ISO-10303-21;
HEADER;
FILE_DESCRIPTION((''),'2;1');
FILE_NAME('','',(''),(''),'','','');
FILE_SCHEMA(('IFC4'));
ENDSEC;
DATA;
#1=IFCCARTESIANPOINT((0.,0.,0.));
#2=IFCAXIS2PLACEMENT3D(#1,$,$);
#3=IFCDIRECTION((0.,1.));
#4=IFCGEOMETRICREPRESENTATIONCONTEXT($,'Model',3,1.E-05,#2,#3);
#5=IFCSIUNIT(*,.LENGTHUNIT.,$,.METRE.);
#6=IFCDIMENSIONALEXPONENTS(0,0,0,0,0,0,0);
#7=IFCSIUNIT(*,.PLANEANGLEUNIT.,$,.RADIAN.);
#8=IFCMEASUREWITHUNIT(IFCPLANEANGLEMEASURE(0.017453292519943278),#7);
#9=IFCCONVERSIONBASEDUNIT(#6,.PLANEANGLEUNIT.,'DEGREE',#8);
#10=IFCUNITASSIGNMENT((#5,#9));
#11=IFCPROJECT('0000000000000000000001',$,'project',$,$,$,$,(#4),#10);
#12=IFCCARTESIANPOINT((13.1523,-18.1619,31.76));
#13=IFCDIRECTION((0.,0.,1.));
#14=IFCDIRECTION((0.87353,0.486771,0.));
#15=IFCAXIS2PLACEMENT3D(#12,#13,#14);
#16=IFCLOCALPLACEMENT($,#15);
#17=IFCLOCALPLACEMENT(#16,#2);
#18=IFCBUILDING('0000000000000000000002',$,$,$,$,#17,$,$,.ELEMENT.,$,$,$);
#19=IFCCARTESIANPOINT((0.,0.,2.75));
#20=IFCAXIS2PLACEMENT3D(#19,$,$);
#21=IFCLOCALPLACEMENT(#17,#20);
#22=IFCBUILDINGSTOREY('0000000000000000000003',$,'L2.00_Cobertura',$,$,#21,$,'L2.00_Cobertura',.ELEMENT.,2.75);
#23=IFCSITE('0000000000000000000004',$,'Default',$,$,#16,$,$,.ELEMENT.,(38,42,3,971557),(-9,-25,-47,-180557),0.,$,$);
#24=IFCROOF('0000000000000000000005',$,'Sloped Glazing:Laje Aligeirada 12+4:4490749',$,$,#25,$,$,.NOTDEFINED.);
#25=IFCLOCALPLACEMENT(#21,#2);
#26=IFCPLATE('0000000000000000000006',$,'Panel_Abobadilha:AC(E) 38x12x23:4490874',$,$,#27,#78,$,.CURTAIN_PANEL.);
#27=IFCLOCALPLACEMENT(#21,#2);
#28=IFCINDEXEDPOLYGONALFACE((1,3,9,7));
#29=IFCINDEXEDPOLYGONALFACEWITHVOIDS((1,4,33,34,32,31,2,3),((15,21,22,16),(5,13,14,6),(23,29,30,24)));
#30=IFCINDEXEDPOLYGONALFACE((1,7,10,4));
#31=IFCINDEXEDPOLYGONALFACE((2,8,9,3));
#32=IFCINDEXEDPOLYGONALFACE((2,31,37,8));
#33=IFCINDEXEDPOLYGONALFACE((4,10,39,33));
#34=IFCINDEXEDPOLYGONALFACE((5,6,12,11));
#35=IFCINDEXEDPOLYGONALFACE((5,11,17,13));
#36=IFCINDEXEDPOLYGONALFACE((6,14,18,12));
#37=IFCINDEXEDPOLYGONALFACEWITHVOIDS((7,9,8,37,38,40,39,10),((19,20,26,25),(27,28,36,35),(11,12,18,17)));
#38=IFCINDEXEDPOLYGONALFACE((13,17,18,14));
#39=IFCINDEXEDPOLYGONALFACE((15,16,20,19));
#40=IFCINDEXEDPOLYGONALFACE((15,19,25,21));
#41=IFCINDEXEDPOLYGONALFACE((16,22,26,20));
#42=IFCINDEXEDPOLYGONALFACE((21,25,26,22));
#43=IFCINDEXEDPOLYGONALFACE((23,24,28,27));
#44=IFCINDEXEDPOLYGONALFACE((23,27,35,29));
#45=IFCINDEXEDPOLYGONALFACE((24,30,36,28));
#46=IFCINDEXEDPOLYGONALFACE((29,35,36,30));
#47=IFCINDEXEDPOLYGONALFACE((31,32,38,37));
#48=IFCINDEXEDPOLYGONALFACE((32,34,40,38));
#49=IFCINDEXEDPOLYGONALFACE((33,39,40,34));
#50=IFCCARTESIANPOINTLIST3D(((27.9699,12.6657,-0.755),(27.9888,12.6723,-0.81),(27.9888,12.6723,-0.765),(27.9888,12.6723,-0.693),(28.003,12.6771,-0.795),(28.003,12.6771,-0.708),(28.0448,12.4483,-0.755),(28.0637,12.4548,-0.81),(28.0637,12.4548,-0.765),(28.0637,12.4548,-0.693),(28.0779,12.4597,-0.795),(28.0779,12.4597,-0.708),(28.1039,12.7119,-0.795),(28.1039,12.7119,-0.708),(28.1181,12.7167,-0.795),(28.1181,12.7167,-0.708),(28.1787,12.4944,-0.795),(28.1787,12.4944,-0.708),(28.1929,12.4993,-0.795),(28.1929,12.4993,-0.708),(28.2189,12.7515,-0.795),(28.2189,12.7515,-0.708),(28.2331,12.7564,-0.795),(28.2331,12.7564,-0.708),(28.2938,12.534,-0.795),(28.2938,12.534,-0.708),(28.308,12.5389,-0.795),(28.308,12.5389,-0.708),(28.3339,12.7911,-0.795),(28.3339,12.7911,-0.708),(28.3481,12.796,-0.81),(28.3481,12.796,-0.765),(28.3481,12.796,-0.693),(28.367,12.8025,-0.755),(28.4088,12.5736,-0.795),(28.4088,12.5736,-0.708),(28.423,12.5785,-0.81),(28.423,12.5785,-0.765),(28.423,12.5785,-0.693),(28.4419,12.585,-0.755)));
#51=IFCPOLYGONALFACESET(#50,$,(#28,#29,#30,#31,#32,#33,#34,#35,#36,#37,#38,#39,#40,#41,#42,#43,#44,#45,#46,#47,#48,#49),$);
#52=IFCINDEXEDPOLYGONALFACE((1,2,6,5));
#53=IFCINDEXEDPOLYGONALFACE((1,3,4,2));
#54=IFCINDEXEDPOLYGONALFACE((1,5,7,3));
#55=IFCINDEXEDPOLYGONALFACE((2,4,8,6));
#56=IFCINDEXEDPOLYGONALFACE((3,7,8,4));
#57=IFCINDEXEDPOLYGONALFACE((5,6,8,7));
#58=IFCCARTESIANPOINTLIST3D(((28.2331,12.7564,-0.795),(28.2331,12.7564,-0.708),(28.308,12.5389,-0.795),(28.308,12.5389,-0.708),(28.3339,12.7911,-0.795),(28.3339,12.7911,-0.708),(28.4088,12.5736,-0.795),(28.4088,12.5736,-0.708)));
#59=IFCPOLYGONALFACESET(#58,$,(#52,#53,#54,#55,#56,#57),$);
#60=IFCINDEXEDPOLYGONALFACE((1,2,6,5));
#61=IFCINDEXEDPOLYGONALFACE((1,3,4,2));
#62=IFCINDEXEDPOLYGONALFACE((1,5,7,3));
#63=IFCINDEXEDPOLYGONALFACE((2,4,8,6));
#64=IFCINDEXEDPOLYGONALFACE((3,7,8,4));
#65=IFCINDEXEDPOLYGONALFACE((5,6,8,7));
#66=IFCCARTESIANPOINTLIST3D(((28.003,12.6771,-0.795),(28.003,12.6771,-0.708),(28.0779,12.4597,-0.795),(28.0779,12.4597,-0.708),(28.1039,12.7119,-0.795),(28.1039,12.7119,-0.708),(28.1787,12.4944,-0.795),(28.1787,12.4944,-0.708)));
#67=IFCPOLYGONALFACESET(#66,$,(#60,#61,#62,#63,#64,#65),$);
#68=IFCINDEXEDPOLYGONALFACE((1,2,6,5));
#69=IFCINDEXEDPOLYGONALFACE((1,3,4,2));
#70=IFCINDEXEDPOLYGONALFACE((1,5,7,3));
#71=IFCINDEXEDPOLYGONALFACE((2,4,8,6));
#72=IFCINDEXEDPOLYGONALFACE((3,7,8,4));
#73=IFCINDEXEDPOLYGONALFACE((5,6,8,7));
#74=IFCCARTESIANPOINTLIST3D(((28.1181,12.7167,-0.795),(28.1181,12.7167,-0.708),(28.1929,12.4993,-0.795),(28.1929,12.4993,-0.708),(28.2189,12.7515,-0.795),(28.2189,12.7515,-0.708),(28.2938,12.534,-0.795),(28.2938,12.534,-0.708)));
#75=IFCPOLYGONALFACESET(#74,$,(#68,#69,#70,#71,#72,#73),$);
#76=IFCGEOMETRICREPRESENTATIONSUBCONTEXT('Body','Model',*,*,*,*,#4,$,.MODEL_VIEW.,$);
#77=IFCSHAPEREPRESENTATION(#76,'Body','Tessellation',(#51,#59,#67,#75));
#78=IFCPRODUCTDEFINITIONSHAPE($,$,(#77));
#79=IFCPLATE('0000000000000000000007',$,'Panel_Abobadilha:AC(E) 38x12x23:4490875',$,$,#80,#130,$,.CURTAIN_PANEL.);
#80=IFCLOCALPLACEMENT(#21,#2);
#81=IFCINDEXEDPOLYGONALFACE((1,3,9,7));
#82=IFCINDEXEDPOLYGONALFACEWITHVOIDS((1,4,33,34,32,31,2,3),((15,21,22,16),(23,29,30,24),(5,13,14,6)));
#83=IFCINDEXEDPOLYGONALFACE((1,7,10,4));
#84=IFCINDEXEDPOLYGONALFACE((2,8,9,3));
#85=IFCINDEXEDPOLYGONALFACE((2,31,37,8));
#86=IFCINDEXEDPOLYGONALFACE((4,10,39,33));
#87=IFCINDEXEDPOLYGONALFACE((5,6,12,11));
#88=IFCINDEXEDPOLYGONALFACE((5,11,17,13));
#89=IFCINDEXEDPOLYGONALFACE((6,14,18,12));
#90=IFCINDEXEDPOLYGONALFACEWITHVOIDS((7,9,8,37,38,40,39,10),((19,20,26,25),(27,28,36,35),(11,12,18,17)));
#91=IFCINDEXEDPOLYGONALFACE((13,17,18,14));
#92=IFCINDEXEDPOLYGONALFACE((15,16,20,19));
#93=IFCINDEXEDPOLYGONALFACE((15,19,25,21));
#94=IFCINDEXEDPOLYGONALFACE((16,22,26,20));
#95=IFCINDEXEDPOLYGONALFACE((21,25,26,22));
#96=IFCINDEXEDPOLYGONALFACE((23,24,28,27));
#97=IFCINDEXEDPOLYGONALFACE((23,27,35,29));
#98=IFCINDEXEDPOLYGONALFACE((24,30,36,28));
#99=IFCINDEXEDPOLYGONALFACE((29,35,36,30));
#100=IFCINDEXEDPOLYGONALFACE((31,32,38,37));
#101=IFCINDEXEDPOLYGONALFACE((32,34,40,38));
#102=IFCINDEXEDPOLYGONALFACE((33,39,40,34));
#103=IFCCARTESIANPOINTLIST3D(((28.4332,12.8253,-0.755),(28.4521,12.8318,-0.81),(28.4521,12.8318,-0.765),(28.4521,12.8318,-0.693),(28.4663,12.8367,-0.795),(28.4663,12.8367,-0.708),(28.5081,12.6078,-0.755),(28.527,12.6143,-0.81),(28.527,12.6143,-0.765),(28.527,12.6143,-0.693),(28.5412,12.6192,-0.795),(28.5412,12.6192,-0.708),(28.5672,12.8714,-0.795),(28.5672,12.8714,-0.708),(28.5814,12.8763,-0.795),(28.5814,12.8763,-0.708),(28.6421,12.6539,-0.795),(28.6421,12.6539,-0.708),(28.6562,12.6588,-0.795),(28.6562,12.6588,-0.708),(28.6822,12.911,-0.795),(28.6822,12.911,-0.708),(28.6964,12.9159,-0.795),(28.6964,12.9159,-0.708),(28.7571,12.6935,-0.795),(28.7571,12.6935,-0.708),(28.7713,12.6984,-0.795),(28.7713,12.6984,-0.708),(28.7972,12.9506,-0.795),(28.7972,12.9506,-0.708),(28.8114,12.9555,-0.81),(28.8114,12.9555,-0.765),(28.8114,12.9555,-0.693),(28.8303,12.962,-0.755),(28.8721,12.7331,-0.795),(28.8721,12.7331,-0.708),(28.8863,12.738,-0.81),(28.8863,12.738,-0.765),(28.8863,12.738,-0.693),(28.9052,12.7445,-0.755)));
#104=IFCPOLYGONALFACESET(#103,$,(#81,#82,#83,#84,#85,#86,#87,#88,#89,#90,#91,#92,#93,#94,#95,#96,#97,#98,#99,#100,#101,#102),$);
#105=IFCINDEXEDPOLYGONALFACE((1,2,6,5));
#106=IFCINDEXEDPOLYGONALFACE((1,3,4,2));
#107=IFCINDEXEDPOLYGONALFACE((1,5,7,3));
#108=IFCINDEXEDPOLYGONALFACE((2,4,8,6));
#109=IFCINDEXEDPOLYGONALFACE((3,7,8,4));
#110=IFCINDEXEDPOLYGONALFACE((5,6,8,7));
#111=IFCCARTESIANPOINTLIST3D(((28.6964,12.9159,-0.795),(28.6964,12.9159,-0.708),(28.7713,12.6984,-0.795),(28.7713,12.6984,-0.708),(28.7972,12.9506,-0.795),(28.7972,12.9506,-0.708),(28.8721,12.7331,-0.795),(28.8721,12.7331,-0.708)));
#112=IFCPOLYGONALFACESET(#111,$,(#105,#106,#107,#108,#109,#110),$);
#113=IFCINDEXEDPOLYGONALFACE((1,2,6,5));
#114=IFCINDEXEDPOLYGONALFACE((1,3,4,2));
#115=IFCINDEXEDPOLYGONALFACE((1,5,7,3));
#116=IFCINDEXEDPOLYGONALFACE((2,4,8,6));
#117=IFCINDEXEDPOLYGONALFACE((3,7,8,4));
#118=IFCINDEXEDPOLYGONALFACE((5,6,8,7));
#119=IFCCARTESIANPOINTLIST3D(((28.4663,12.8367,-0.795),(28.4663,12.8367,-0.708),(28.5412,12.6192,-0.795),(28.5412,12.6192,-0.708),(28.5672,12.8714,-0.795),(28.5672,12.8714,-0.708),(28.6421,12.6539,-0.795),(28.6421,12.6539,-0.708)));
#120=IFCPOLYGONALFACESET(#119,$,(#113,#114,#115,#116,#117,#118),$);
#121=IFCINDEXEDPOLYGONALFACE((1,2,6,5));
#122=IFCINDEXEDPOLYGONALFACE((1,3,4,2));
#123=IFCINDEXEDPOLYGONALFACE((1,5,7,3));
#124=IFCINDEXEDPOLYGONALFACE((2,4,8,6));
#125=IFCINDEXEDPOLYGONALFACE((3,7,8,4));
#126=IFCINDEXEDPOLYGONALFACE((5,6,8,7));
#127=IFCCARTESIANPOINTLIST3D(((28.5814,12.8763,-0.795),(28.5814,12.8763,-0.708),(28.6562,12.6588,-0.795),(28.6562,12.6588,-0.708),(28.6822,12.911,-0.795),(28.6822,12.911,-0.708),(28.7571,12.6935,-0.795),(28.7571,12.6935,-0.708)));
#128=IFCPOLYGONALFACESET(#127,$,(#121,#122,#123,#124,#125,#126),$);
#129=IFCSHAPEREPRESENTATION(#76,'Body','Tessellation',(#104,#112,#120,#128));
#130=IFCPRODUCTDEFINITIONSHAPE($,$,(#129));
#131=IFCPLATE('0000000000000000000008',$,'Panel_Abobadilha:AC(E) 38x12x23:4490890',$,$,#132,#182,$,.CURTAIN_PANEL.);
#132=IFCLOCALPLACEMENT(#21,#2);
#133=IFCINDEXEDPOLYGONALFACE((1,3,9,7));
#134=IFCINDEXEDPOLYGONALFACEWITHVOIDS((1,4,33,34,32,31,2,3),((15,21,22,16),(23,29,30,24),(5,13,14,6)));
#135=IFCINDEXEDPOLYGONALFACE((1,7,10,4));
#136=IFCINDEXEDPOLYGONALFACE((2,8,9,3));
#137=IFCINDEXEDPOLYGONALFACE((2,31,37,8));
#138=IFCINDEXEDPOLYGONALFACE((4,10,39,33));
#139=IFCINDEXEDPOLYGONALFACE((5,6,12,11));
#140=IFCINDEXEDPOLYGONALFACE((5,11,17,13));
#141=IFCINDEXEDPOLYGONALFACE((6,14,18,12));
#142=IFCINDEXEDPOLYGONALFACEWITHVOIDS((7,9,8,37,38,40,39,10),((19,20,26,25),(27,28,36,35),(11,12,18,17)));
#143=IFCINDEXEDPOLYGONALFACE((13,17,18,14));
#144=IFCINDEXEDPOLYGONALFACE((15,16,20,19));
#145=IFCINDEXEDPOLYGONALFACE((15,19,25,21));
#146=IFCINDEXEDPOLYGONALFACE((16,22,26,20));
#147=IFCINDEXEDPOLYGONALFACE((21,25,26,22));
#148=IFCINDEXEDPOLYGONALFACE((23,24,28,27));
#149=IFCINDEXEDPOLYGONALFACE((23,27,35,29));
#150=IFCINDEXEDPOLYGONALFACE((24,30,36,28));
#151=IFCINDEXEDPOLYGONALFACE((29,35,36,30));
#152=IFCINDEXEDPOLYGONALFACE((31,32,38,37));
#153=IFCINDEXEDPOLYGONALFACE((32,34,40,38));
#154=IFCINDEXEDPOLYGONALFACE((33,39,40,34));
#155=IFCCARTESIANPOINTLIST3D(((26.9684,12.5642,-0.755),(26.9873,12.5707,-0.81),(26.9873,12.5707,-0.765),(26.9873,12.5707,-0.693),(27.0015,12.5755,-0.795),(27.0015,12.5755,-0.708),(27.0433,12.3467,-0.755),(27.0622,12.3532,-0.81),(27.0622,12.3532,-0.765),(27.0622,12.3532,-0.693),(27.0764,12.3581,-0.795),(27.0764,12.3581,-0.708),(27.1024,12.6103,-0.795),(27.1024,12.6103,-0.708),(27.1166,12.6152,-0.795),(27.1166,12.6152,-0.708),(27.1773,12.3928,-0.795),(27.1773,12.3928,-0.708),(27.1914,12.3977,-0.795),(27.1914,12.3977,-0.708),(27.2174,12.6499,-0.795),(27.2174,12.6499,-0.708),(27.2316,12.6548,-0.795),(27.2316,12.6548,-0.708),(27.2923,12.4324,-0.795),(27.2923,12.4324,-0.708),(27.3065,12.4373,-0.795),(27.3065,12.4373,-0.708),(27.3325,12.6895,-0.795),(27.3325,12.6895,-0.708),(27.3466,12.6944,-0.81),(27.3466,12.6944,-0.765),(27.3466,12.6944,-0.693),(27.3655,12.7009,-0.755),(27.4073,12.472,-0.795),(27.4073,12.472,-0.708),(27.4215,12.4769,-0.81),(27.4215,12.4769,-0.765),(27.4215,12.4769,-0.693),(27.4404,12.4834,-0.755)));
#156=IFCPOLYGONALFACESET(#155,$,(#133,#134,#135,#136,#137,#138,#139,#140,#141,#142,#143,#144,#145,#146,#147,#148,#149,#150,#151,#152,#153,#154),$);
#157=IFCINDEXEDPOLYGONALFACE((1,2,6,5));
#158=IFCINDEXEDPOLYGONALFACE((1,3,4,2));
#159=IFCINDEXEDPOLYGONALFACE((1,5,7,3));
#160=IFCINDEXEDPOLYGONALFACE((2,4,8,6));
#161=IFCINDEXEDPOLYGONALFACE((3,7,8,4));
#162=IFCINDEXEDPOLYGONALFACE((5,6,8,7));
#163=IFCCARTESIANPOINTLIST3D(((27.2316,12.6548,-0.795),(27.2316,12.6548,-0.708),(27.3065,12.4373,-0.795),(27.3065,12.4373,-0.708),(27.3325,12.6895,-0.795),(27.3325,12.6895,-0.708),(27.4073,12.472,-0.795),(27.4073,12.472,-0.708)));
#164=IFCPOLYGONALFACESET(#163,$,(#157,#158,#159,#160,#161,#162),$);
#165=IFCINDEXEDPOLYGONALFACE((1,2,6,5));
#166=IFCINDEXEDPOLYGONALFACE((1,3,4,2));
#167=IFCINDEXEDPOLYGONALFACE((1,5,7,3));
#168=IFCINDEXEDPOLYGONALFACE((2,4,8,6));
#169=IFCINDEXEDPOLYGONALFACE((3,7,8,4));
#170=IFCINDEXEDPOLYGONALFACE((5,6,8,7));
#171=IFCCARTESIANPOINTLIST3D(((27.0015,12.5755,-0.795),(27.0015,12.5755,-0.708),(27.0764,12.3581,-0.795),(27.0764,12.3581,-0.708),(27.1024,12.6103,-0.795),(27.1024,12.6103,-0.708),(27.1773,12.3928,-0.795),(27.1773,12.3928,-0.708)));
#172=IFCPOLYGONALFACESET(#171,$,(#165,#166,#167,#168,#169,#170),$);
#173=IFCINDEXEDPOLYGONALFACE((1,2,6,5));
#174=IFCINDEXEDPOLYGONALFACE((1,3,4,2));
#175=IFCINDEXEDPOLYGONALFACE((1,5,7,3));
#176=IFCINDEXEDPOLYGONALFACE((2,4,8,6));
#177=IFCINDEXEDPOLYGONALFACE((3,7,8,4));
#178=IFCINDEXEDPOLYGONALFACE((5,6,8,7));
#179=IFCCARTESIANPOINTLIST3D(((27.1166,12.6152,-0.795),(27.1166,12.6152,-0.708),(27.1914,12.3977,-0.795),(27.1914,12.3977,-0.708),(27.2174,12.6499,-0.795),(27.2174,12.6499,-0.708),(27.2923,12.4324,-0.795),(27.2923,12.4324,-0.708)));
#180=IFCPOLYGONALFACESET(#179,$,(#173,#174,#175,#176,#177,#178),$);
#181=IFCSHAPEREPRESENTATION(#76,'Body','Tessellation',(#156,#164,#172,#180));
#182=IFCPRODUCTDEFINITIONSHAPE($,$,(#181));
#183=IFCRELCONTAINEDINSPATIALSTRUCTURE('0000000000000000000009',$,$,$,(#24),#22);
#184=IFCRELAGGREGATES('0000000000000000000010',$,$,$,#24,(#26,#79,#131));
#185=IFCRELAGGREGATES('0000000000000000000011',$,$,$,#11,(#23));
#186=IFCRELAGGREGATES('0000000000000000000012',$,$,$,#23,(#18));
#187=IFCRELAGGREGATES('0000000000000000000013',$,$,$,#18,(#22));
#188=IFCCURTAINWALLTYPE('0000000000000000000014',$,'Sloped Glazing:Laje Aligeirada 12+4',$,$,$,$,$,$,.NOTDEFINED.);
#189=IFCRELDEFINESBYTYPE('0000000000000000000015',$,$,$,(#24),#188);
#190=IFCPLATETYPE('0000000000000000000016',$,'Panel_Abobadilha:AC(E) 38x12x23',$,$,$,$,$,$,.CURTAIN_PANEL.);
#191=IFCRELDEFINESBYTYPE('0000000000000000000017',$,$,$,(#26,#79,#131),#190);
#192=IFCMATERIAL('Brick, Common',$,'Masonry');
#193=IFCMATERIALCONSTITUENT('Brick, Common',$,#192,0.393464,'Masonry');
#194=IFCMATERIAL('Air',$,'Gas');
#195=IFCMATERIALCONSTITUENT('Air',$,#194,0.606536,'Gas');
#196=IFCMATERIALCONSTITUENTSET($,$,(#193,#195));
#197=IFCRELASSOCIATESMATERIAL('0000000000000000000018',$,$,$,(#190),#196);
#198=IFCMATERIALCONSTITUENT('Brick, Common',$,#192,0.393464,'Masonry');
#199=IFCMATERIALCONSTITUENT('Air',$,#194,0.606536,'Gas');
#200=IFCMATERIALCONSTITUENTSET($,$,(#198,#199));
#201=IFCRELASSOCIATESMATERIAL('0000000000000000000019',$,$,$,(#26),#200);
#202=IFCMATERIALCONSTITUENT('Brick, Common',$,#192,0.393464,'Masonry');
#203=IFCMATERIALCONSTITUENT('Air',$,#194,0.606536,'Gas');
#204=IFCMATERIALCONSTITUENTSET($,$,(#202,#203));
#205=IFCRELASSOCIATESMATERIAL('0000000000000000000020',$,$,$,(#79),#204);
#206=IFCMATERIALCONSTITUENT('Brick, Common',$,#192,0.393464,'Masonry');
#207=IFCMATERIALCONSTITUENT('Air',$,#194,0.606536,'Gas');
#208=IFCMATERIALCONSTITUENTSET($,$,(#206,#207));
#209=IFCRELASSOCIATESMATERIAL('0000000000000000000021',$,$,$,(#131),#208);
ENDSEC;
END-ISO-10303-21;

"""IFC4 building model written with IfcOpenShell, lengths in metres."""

from ifc_helpers import new_model, entity, si_unit, converted_unit, direction, frame, origin, place, context, subcontext, project, spatial, indexed_curve, outline, extrude, source, transform, mapped, material, constituent, constituent_set, type_object, type_shapes, element, aggregate, save


model = new_model("IFC4")

# Units and contexts
model_context = context("Model", 3, precision=1e-05, world=origin(), true_north=direction((0.0, 1.0)))
body_context = subcontext(model_context, "Body", "Model", "MODEL_VIEW")
ifc_project = project(units=[si_unit("LENGTHUNIT", "METRE"), converted_unit("PLANEANGLEUNIT", "DEGREE", entity("IfcPlaneAngleMeasure", 0.017453292519943278), si_unit("PLANEANGLEUNIT", "RADIAN"), dimensions=[0, 0, 0, 0, 0, 0, 0])], contexts=[model_context])

# Site, building, storey
site_placement = place(None, frame((13.1523, -18.1619, 31.76), z_axis=(0.0, 0.0, 1.0), x_axis=(0.87353, 0.486771, 0.0)))
site = spatial("IfcSite", under=ifc_project, at=site_placement, Name="Default", CompositionType="ELEMENT", RefLatitude=(38, 42, 3, 971557), RefLongitude=(-9, -25, -47, -180557), RefElevation=0.0)
building_placement = place(site_placement, origin())
building = spatial("IfcBuilding", under=site, at=building_placement, CompositionType="ELEMENT")
storey_placement = place(building_placement, frame((0.0, 0.0, 2.75)))
storey = spatial("IfcBuildingStorey", under=building, at=storey_placement, Name="L2.00_Cobertura", LongName="L2.00_Cobertura", CompositionType="ELEMENT", Elevation=2.75)

# Roof, plates
curtain_wall_type = type_object("IfcCurtainWallType", Name="Sloped Glazing:Laje Aligeirada 12+4", PredefinedType="NOTDEFINED")
roof_placement = place(storey_placement, frame((0.0, 0.0, -2.75)))
roof = element("IfcRoof", 1, at=roof_placement, inside=storey, type_object=curtain_wall_type, Name="Sloped Glazing:Laje Aligeirada 12+4:4490749", PredefinedType="NOTDEFINED")
ifc_material_1 = material(Name="Brick, Common", Category="Masonry")
ifc_material_2 = material(Name="Air", Category="Gas")
ifc_constituent_1 = constituent(ifc_material_1, Name="Brick, Common", Category="Masonry", fraction=0.393464)
ifc_constituent_2 = constituent(ifc_material_2, Name="Air", Category="Gas", fraction=0.606536)
ifc_constituent_set_1 = constituent_set(constituents=[ifc_constituent_1, ifc_constituent_2])
plate_type_1 = type_object("IfcPlateType", Name="Panel_Abobadilha:AC(E) 38x12x23", PredefinedType="CURTAIN_PANEL", material=ifc_constituent_set_1)
shared_shape_1 = source(origin(), body_context, "Body", "SweptSolid", [
    extrude(outline(indexed_curve([(-0.19, -0.0543), (0.19, -0.0543), (0.19, -0.0093), (0.21, 0.0007), (0.19, 0.0628), (-0.19, 0.0628), (-0.21, 0.0007), (-0.19, -0.0093), (-0.19, -0.0543)], self_intersect=False), holes=[indexed_curve([(-0.0683, 0.0477), (-0.0683, -0.0393), (-0.175, -0.0393), (-0.175, 0.0477), (-0.0683, 0.0477)], self_intersect=False), indexed_curve([(0.0533, 0.0477), (0.0533, -0.0393), (-0.0533, -0.0393), (-0.0533, 0.0477), (0.0533, 0.0477)], self_intersect=False), indexed_curve([(0.175, 0.0477), (0.175, -0.0393), (0.0683, -0.0393), (0.0683, 0.0477), (0.175, 0.0477)], self_intersect=False)]), frame((0.0, 0.0543, 0.0)), (0.0, 0.0, 1.0), 0.23),
    extrude(outline(indexed_curve([(-0.0533, -0.0435), (0.0533, -0.0435), (0.0533, 0.0435), (-0.0533, 0.0435), (-0.0533, -0.0435)], self_intersect=False)), frame((0.1217, 0.0585, 0.0), z_axis=(0.0, 0.0, 1.0), x_axis=(-1.0, 0.0, 0.0)), (0.0, 0.0, 1.0), 0.23),
    extrude(outline(indexed_curve([(-0.0533, -0.0435), (0.0533, -0.0435), (0.0533, 0.0435), (-0.0533, 0.0435), (-0.0533, -0.0435)], self_intersect=False)), frame((-0.1217, 0.0585, 0.0), z_axis=(0.0, 0.0, 1.0), x_axis=(-1.0, 0.0, 0.0)), (0.0, 0.0, 1.0), 0.23),
    extrude(outline(indexed_curve([(-0.0533, -0.0435), (0.0533, -0.0435), (0.0533, 0.0435), (-0.0533, 0.0435), (-0.0533, -0.0435)], self_intersect=False)), frame((0.0, 0.0585, 0.0), z_axis=(0.0, 0.0, 1.0), x_axis=(-1.0, 0.0, 0.0)), (0.0, 0.0, 1.0), 0.23),
])
type_shapes(plate_type_1, [shared_shape_1])
ifc_constituent_3 = constituent(ifc_material_1, Name="Brick, Common", Category="Masonry", fraction=0.393464)
ifc_constituent_4 = constituent(ifc_material_2, Name="Air", Category="Gas", fraction=0.606536)
ifc_constituent_set_2 = constituent_set(constituents=[ifc_constituent_3, ifc_constituent_4])
plate_1_placement = place(roof_placement, frame((28.1685, 12.7341, 1.94), z_axis=(0.325568, -0.945519, 0.0), x_axis=(0.945519, 0.325568, 0.0)))
plate_1 = element("IfcPlate", 2, at=plate_1_placement, type_object=plate_type_1, material=ifc_constituent_set_2, Name="Panel_Abobadilha:AC(E) 38x12x23:4490874", PredefinedType="CURTAIN_PANEL", context=body_context, shape_type="MappedRepresentation", body=[
    mapped(shared_shape_1, transform((0.0, 0.0, 0.0), scale=1.0)),
])
ifc_constituent_5 = constituent(ifc_material_1, Name="Brick, Common", Category="Masonry", fraction=0.393464)
ifc_constituent_6 = constituent(ifc_material_2, Name="Air", Category="Gas", fraction=0.606536)
ifc_constituent_set_3 = constituent_set(constituents=[ifc_constituent_5, ifc_constituent_6])
plate_2_placement = place(roof_placement, frame((28.6318, 12.8936, 1.94), z_axis=(0.325568, -0.945519, 0.0), x_axis=(0.945519, 0.325568, 0.0)))
plate_2 = element("IfcPlate", 3, at=plate_2_placement, type_object=plate_type_1, material=ifc_constituent_set_3, Name="Panel_Abobadilha:AC(E) 38x12x23:4490875", PredefinedType="CURTAIN_PANEL", context=body_context, shape_type="MappedRepresentation", body=[
    mapped(shared_shape_1, transform((0.0, 0.0, 0.0), scale=1.0)),
])
ifc_constituent_7 = constituent(ifc_material_1, Name="Brick, Common", Category="Masonry", fraction=0.393464)
ifc_constituent_8 = constituent(ifc_material_2, Name="Air", Category="Gas", fraction=0.606536)
ifc_constituent_set_4 = constituent_set(constituents=[ifc_constituent_7, ifc_constituent_8])
plate_3_placement = place(roof_placement, frame((27.167, 12.6325, 1.94), z_axis=(0.325568, -0.945519, 0.0), x_axis=(0.945519, 0.325568, 0.0)))
plate_3 = element("IfcPlate", 4, at=plate_3_placement, type_object=plate_type_1, material=ifc_constituent_set_4, Name="Panel_Abobadilha:AC(E) 38x12x23:4490890", PredefinedType="CURTAIN_PANEL", context=body_context, shape_type="MappedRepresentation", body=[
    mapped(shared_shape_1, transform((0.0, 0.0, 0.0), scale=1.0)),
])
aggregate(roof, [plate_1, plate_2, plate_3])

save(model, "model.ifc")
